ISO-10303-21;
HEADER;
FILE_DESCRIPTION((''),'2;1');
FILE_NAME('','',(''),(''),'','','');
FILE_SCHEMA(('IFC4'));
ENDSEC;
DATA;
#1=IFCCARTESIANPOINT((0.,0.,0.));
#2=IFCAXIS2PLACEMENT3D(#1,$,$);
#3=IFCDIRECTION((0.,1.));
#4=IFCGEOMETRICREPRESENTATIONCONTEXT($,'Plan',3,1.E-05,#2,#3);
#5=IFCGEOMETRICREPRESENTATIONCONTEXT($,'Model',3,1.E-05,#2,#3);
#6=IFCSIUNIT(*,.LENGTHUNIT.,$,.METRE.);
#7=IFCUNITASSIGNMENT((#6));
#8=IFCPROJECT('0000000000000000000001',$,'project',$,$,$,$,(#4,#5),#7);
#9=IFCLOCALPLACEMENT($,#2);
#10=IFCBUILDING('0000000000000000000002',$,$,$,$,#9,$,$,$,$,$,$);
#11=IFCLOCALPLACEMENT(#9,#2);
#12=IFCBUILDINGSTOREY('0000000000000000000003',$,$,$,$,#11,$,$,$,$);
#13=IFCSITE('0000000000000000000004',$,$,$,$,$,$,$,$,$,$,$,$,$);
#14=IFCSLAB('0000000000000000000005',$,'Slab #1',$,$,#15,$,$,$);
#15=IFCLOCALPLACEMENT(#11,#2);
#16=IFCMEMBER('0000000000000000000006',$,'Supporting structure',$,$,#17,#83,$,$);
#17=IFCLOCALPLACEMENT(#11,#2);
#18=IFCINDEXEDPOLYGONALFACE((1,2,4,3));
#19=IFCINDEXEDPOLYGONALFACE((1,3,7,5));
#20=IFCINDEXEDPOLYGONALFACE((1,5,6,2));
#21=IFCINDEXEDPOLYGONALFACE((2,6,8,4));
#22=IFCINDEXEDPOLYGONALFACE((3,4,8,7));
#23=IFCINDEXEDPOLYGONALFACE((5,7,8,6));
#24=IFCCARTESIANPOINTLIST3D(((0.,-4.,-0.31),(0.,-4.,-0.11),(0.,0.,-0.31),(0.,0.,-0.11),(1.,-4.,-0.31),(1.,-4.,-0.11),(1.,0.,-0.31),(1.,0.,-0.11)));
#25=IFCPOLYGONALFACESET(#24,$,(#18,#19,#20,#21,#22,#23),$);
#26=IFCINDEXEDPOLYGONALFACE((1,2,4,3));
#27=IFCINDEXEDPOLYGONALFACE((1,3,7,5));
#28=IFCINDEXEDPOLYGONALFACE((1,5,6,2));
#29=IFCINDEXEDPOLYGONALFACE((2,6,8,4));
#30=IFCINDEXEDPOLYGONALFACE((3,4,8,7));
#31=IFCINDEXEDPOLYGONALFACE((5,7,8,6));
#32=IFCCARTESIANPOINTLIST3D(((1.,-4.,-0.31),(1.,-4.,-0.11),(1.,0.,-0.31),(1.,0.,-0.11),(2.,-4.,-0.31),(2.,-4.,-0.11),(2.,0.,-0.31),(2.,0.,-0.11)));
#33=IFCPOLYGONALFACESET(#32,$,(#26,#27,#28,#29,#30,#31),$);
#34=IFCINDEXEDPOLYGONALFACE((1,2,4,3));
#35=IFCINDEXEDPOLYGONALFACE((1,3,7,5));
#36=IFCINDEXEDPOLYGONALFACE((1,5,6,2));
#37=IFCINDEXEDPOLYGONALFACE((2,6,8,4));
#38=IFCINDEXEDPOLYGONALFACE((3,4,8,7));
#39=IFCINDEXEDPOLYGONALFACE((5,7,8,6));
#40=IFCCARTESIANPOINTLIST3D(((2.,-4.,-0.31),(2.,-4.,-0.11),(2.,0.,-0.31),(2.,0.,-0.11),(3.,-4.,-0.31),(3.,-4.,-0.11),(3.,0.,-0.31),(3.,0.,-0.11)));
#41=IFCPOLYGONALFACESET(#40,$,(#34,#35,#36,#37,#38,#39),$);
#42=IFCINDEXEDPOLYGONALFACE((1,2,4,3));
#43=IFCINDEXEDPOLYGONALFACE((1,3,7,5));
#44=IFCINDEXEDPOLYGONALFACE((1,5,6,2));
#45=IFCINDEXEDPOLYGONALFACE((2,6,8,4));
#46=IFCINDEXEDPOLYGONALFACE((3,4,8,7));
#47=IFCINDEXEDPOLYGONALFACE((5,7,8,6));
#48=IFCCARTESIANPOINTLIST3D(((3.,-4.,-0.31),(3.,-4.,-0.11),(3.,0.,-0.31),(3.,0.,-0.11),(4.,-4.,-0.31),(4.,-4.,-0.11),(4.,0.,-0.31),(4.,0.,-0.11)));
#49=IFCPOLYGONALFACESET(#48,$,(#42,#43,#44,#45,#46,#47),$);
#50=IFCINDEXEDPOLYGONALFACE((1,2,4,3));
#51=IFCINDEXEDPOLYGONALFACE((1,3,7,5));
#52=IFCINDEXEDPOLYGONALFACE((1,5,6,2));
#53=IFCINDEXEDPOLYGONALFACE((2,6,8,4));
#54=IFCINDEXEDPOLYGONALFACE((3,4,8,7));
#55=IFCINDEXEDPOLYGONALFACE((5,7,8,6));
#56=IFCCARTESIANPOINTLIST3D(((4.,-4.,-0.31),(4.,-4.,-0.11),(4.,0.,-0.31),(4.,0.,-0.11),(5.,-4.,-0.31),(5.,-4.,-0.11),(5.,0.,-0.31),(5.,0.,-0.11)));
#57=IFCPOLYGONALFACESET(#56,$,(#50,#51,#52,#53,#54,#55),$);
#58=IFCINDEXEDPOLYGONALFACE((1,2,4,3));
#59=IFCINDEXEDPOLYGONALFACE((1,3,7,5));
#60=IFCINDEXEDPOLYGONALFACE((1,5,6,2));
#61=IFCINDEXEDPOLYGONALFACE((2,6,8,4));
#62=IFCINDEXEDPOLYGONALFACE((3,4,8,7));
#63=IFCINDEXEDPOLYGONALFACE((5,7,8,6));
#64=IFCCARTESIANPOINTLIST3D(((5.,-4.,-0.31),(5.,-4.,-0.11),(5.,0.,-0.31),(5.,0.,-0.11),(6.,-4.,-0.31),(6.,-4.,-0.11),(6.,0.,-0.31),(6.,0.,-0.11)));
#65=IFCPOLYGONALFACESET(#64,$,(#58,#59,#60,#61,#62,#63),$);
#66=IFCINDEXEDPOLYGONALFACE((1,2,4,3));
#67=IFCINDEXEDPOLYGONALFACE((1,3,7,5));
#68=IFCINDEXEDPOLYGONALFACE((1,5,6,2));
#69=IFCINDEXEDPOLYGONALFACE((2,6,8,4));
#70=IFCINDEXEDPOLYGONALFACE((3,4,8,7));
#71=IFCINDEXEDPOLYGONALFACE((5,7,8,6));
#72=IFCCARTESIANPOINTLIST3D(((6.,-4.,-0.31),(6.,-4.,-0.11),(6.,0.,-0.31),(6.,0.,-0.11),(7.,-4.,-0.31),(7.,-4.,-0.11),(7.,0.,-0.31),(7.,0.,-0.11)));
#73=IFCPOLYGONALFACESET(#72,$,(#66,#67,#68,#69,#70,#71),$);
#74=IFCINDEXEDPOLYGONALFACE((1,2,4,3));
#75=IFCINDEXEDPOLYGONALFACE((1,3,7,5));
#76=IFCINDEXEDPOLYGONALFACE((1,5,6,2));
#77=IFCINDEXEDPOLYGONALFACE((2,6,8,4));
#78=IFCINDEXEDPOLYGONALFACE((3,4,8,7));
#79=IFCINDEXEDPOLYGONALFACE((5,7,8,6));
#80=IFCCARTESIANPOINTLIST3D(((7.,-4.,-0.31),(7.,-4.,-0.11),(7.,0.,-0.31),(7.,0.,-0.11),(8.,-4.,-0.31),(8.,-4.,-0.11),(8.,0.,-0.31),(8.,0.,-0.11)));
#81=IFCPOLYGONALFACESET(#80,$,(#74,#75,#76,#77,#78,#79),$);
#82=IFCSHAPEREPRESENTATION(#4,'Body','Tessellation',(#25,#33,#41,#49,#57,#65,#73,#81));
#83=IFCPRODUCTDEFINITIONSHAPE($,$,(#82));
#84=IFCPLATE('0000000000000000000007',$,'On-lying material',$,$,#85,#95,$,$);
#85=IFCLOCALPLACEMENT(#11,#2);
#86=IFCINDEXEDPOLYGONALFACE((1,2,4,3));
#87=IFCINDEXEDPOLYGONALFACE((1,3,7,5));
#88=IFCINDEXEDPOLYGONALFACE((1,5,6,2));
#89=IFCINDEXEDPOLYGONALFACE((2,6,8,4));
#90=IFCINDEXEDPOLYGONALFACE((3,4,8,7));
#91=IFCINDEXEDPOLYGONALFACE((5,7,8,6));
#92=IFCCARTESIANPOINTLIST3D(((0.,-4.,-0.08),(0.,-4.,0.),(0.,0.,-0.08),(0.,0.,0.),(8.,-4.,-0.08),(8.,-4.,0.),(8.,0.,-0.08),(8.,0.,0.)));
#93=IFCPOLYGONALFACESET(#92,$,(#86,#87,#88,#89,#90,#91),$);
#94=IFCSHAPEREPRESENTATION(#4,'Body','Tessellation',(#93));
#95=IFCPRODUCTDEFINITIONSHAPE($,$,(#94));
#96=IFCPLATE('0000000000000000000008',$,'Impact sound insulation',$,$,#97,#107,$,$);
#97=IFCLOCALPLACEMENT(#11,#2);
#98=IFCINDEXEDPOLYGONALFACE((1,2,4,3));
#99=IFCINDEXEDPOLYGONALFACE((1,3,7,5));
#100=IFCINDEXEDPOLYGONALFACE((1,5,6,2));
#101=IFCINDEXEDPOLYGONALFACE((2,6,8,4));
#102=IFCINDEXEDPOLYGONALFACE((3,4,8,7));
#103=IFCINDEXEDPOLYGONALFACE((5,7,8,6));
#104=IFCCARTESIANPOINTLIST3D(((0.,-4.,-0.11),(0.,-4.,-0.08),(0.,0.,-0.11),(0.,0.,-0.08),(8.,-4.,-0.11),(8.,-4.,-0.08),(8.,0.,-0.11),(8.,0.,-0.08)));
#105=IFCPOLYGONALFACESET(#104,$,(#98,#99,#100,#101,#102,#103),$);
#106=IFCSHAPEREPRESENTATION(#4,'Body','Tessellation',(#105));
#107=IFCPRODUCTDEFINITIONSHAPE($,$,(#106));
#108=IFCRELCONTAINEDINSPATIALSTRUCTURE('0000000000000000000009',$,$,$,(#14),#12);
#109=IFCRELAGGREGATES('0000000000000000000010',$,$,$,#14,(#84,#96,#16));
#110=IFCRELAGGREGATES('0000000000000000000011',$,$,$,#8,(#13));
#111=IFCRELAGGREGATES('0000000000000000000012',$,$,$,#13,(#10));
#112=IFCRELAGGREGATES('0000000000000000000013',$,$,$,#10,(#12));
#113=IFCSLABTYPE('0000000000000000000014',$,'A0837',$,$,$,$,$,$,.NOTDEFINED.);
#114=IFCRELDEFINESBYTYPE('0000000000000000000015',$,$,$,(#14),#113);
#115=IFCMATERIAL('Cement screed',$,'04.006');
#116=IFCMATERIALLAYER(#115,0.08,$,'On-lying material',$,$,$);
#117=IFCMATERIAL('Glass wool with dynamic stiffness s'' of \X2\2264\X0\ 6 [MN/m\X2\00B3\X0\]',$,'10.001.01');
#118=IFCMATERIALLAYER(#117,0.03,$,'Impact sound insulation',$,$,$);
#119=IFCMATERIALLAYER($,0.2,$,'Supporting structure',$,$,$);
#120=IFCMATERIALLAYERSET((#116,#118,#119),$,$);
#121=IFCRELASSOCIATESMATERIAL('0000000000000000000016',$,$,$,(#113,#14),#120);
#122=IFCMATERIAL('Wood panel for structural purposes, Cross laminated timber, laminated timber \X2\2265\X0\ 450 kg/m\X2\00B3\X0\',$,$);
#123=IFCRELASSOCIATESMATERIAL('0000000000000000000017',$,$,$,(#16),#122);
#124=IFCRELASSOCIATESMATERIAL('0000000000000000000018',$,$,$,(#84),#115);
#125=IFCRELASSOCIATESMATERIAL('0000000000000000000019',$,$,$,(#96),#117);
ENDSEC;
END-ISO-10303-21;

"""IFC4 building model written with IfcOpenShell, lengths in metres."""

from ifc_helpers import new_model, si_unit, direction, frame, frame_2d, origin, origin_with_axes, place, context, project, spatial, rectangle, extrude, material, layer, layer_set, type_object, element, aggregate, save


model = new_model("IFC4")

# Units and contexts
plan_context = context("Plan", 3, precision=1e-05, world=origin(), true_north=direction((0.0, 1.0)))
model_context = context("Model", 3, precision=1e-05, world=origin(), true_north=direction((0.0, 1.0)))
ifc_project = project(units=[si_unit("LENGTHUNIT", "METRE")], contexts=[plan_context, model_context])

# Site, building, storey
site = spatial("IfcSite", under=ifc_project)
building_placement = place(None, origin())
building = spatial("IfcBuilding", under=site, at=building_placement)
storey_placement = place(building_placement, origin())
storey = spatial("IfcBuildingStorey", under=building, at=storey_placement)

# Slab, member, plates
ifc_material_1 = material(Name="Cement screed", Category="04.006")
ifc_layer_1 = layer(ifc_material_1, 0.08, Name="On-lying material")
ifc_material_2 = material(Name="Glass wool with dynamic stiffness s' of ≤ 6 [MN/m³]", Category="10.001.01")
ifc_layer_2 = layer(ifc_material_2, 0.03, Name="Impact sound insulation")
ifc_layer_3 = layer(None, 0.2, Name="Supporting structure")
ifc_layer_set = layer_set([ifc_layer_1, ifc_layer_2, ifc_layer_3])
slab_type = type_object("IfcSlabType", Name="A0837", PredefinedType="NOTDEFINED", material=ifc_layer_set)
slab_placement = place(None, frame((0.0, 0.0, 0.0), z_axis=(0.0, 0.0, -1.0), x_axis=(1.0, 0.0, 0.0)))
slab = element("IfcSlab", 1, at=slab_placement, inside=storey, type_object=slab_type, material=ifc_layer_set, Name="Slab #1")
ifc_material_3 = material(Name="Wood panel for structural purposes, Cross laminated timber, laminated timber ≥ 450 kg/m³")
member_placement = place(slab_placement, origin())
member = element("IfcMember", 2, at=member_placement, material=ifc_material_3, Name="Supporting structure", context=plan_context, shape_type="SweptSolid", body=[
    extrude(rectangle(XDim=1.0, YDim=0.2, at=frame_2d((0.5, 0.1), x_axis=(1.0, 0.0))), frame((0.0, 4.0, 0.11), z_axis=(0.0, -1.0, 0.0), x_axis=(1.0, 0.0, 0.0)), (0.0, 0.0, 1.0), 4.0),
    extrude(rectangle(XDim=1.0, YDim=0.2, at=frame_2d((0.5, 0.1), x_axis=(1.0, 0.0))), frame((1.0, 4.0, 0.11), z_axis=(0.0, -1.0, 0.0), x_axis=(1.0, 0.0, 0.0)), (0.0, 0.0, 1.0), 4.0),
    extrude(rectangle(XDim=1.0, YDim=0.2, at=frame_2d((0.5, 0.1), x_axis=(1.0, 0.0))), frame((2.0, 4.0, 0.11), z_axis=(0.0, -1.0, 0.0), x_axis=(1.0, 0.0, 0.0)), (0.0, 0.0, 1.0), 4.0),
    extrude(rectangle(XDim=1.0, YDim=0.2, at=frame_2d((0.5, 0.1), x_axis=(1.0, 0.0))), frame((3.0, 4.0, 0.11), z_axis=(0.0, -1.0, 0.0), x_axis=(1.0, 0.0, 0.0)), (0.0, 0.0, 1.0), 4.0),
    extrude(rectangle(XDim=1.0, YDim=0.2, at=frame_2d((0.5, 0.1), x_axis=(1.0, 0.0))), frame((4.0, 4.0, 0.11), z_axis=(0.0, -1.0, 0.0), x_axis=(1.0, 0.0, 0.0)), (0.0, 0.0, 1.0), 4.0),
    extrude(rectangle(XDim=1.0, YDim=0.2, at=frame_2d((0.5, 0.1), x_axis=(1.0, 0.0))), frame((5.0, 4.0, 0.11), z_axis=(0.0, -1.0, 0.0), x_axis=(1.0, 0.0, 0.0)), (0.0, 0.0, 1.0), 4.0),
    extrude(rectangle(XDim=1.0, YDim=0.2, at=frame_2d((0.5, 0.1), x_axis=(1.0, 0.0))), frame((6.0, 4.0, 0.11), z_axis=(0.0, -1.0, 0.0), x_axis=(1.0, 0.0, 0.0)), (0.0, 0.0, 1.0), 4.0),
    extrude(rectangle(XDim=1.0, YDim=0.2, at=frame_2d((0.5, 0.1), x_axis=(1.0, 0.0))), frame((7.0, 4.0, 0.11), z_axis=(0.0, -1.0, 0.0), x_axis=(1.0, 0.0, 0.0)), (0.0, 0.0, 1.0), 4.0),
])
plate_1_placement = place(slab_placement, origin())
plate_1 = element("IfcPlate", 3, at=plate_1_placement, material=ifc_material_1, Name="On-lying material", context=plan_context, shape_type="SweptSolid", body=[
    extrude(rectangle(XDim=8.0, YDim=4.0, at=frame_2d((4.0, 2.0), x_axis=(1.0, 0.0))), origin_with_axes(), (0.0, 0.0, 1.0), 0.08),
])
plate_2_placement = place(slab_placement, origin())
plate_2 = element("IfcPlate", 4, at=plate_2_placement, material=ifc_material_2, Name="Impact sound insulation", context=plan_context, shape_type="SweptSolid", body=[
    extrude(rectangle(XDim=8.0, YDim=4.0, at=frame_2d((4.0, 2.0), x_axis=(1.0, 0.0))), frame((0.0, 0.0, 0.08), z_axis=(0.0, 0.0, 1.0), x_axis=(1.0, 0.0, 0.0)), (0.0, 0.0, 1.0), 0.03),
])
aggregate(slab, [plate_1, plate_2, member])

save(model, "model.ifc")
